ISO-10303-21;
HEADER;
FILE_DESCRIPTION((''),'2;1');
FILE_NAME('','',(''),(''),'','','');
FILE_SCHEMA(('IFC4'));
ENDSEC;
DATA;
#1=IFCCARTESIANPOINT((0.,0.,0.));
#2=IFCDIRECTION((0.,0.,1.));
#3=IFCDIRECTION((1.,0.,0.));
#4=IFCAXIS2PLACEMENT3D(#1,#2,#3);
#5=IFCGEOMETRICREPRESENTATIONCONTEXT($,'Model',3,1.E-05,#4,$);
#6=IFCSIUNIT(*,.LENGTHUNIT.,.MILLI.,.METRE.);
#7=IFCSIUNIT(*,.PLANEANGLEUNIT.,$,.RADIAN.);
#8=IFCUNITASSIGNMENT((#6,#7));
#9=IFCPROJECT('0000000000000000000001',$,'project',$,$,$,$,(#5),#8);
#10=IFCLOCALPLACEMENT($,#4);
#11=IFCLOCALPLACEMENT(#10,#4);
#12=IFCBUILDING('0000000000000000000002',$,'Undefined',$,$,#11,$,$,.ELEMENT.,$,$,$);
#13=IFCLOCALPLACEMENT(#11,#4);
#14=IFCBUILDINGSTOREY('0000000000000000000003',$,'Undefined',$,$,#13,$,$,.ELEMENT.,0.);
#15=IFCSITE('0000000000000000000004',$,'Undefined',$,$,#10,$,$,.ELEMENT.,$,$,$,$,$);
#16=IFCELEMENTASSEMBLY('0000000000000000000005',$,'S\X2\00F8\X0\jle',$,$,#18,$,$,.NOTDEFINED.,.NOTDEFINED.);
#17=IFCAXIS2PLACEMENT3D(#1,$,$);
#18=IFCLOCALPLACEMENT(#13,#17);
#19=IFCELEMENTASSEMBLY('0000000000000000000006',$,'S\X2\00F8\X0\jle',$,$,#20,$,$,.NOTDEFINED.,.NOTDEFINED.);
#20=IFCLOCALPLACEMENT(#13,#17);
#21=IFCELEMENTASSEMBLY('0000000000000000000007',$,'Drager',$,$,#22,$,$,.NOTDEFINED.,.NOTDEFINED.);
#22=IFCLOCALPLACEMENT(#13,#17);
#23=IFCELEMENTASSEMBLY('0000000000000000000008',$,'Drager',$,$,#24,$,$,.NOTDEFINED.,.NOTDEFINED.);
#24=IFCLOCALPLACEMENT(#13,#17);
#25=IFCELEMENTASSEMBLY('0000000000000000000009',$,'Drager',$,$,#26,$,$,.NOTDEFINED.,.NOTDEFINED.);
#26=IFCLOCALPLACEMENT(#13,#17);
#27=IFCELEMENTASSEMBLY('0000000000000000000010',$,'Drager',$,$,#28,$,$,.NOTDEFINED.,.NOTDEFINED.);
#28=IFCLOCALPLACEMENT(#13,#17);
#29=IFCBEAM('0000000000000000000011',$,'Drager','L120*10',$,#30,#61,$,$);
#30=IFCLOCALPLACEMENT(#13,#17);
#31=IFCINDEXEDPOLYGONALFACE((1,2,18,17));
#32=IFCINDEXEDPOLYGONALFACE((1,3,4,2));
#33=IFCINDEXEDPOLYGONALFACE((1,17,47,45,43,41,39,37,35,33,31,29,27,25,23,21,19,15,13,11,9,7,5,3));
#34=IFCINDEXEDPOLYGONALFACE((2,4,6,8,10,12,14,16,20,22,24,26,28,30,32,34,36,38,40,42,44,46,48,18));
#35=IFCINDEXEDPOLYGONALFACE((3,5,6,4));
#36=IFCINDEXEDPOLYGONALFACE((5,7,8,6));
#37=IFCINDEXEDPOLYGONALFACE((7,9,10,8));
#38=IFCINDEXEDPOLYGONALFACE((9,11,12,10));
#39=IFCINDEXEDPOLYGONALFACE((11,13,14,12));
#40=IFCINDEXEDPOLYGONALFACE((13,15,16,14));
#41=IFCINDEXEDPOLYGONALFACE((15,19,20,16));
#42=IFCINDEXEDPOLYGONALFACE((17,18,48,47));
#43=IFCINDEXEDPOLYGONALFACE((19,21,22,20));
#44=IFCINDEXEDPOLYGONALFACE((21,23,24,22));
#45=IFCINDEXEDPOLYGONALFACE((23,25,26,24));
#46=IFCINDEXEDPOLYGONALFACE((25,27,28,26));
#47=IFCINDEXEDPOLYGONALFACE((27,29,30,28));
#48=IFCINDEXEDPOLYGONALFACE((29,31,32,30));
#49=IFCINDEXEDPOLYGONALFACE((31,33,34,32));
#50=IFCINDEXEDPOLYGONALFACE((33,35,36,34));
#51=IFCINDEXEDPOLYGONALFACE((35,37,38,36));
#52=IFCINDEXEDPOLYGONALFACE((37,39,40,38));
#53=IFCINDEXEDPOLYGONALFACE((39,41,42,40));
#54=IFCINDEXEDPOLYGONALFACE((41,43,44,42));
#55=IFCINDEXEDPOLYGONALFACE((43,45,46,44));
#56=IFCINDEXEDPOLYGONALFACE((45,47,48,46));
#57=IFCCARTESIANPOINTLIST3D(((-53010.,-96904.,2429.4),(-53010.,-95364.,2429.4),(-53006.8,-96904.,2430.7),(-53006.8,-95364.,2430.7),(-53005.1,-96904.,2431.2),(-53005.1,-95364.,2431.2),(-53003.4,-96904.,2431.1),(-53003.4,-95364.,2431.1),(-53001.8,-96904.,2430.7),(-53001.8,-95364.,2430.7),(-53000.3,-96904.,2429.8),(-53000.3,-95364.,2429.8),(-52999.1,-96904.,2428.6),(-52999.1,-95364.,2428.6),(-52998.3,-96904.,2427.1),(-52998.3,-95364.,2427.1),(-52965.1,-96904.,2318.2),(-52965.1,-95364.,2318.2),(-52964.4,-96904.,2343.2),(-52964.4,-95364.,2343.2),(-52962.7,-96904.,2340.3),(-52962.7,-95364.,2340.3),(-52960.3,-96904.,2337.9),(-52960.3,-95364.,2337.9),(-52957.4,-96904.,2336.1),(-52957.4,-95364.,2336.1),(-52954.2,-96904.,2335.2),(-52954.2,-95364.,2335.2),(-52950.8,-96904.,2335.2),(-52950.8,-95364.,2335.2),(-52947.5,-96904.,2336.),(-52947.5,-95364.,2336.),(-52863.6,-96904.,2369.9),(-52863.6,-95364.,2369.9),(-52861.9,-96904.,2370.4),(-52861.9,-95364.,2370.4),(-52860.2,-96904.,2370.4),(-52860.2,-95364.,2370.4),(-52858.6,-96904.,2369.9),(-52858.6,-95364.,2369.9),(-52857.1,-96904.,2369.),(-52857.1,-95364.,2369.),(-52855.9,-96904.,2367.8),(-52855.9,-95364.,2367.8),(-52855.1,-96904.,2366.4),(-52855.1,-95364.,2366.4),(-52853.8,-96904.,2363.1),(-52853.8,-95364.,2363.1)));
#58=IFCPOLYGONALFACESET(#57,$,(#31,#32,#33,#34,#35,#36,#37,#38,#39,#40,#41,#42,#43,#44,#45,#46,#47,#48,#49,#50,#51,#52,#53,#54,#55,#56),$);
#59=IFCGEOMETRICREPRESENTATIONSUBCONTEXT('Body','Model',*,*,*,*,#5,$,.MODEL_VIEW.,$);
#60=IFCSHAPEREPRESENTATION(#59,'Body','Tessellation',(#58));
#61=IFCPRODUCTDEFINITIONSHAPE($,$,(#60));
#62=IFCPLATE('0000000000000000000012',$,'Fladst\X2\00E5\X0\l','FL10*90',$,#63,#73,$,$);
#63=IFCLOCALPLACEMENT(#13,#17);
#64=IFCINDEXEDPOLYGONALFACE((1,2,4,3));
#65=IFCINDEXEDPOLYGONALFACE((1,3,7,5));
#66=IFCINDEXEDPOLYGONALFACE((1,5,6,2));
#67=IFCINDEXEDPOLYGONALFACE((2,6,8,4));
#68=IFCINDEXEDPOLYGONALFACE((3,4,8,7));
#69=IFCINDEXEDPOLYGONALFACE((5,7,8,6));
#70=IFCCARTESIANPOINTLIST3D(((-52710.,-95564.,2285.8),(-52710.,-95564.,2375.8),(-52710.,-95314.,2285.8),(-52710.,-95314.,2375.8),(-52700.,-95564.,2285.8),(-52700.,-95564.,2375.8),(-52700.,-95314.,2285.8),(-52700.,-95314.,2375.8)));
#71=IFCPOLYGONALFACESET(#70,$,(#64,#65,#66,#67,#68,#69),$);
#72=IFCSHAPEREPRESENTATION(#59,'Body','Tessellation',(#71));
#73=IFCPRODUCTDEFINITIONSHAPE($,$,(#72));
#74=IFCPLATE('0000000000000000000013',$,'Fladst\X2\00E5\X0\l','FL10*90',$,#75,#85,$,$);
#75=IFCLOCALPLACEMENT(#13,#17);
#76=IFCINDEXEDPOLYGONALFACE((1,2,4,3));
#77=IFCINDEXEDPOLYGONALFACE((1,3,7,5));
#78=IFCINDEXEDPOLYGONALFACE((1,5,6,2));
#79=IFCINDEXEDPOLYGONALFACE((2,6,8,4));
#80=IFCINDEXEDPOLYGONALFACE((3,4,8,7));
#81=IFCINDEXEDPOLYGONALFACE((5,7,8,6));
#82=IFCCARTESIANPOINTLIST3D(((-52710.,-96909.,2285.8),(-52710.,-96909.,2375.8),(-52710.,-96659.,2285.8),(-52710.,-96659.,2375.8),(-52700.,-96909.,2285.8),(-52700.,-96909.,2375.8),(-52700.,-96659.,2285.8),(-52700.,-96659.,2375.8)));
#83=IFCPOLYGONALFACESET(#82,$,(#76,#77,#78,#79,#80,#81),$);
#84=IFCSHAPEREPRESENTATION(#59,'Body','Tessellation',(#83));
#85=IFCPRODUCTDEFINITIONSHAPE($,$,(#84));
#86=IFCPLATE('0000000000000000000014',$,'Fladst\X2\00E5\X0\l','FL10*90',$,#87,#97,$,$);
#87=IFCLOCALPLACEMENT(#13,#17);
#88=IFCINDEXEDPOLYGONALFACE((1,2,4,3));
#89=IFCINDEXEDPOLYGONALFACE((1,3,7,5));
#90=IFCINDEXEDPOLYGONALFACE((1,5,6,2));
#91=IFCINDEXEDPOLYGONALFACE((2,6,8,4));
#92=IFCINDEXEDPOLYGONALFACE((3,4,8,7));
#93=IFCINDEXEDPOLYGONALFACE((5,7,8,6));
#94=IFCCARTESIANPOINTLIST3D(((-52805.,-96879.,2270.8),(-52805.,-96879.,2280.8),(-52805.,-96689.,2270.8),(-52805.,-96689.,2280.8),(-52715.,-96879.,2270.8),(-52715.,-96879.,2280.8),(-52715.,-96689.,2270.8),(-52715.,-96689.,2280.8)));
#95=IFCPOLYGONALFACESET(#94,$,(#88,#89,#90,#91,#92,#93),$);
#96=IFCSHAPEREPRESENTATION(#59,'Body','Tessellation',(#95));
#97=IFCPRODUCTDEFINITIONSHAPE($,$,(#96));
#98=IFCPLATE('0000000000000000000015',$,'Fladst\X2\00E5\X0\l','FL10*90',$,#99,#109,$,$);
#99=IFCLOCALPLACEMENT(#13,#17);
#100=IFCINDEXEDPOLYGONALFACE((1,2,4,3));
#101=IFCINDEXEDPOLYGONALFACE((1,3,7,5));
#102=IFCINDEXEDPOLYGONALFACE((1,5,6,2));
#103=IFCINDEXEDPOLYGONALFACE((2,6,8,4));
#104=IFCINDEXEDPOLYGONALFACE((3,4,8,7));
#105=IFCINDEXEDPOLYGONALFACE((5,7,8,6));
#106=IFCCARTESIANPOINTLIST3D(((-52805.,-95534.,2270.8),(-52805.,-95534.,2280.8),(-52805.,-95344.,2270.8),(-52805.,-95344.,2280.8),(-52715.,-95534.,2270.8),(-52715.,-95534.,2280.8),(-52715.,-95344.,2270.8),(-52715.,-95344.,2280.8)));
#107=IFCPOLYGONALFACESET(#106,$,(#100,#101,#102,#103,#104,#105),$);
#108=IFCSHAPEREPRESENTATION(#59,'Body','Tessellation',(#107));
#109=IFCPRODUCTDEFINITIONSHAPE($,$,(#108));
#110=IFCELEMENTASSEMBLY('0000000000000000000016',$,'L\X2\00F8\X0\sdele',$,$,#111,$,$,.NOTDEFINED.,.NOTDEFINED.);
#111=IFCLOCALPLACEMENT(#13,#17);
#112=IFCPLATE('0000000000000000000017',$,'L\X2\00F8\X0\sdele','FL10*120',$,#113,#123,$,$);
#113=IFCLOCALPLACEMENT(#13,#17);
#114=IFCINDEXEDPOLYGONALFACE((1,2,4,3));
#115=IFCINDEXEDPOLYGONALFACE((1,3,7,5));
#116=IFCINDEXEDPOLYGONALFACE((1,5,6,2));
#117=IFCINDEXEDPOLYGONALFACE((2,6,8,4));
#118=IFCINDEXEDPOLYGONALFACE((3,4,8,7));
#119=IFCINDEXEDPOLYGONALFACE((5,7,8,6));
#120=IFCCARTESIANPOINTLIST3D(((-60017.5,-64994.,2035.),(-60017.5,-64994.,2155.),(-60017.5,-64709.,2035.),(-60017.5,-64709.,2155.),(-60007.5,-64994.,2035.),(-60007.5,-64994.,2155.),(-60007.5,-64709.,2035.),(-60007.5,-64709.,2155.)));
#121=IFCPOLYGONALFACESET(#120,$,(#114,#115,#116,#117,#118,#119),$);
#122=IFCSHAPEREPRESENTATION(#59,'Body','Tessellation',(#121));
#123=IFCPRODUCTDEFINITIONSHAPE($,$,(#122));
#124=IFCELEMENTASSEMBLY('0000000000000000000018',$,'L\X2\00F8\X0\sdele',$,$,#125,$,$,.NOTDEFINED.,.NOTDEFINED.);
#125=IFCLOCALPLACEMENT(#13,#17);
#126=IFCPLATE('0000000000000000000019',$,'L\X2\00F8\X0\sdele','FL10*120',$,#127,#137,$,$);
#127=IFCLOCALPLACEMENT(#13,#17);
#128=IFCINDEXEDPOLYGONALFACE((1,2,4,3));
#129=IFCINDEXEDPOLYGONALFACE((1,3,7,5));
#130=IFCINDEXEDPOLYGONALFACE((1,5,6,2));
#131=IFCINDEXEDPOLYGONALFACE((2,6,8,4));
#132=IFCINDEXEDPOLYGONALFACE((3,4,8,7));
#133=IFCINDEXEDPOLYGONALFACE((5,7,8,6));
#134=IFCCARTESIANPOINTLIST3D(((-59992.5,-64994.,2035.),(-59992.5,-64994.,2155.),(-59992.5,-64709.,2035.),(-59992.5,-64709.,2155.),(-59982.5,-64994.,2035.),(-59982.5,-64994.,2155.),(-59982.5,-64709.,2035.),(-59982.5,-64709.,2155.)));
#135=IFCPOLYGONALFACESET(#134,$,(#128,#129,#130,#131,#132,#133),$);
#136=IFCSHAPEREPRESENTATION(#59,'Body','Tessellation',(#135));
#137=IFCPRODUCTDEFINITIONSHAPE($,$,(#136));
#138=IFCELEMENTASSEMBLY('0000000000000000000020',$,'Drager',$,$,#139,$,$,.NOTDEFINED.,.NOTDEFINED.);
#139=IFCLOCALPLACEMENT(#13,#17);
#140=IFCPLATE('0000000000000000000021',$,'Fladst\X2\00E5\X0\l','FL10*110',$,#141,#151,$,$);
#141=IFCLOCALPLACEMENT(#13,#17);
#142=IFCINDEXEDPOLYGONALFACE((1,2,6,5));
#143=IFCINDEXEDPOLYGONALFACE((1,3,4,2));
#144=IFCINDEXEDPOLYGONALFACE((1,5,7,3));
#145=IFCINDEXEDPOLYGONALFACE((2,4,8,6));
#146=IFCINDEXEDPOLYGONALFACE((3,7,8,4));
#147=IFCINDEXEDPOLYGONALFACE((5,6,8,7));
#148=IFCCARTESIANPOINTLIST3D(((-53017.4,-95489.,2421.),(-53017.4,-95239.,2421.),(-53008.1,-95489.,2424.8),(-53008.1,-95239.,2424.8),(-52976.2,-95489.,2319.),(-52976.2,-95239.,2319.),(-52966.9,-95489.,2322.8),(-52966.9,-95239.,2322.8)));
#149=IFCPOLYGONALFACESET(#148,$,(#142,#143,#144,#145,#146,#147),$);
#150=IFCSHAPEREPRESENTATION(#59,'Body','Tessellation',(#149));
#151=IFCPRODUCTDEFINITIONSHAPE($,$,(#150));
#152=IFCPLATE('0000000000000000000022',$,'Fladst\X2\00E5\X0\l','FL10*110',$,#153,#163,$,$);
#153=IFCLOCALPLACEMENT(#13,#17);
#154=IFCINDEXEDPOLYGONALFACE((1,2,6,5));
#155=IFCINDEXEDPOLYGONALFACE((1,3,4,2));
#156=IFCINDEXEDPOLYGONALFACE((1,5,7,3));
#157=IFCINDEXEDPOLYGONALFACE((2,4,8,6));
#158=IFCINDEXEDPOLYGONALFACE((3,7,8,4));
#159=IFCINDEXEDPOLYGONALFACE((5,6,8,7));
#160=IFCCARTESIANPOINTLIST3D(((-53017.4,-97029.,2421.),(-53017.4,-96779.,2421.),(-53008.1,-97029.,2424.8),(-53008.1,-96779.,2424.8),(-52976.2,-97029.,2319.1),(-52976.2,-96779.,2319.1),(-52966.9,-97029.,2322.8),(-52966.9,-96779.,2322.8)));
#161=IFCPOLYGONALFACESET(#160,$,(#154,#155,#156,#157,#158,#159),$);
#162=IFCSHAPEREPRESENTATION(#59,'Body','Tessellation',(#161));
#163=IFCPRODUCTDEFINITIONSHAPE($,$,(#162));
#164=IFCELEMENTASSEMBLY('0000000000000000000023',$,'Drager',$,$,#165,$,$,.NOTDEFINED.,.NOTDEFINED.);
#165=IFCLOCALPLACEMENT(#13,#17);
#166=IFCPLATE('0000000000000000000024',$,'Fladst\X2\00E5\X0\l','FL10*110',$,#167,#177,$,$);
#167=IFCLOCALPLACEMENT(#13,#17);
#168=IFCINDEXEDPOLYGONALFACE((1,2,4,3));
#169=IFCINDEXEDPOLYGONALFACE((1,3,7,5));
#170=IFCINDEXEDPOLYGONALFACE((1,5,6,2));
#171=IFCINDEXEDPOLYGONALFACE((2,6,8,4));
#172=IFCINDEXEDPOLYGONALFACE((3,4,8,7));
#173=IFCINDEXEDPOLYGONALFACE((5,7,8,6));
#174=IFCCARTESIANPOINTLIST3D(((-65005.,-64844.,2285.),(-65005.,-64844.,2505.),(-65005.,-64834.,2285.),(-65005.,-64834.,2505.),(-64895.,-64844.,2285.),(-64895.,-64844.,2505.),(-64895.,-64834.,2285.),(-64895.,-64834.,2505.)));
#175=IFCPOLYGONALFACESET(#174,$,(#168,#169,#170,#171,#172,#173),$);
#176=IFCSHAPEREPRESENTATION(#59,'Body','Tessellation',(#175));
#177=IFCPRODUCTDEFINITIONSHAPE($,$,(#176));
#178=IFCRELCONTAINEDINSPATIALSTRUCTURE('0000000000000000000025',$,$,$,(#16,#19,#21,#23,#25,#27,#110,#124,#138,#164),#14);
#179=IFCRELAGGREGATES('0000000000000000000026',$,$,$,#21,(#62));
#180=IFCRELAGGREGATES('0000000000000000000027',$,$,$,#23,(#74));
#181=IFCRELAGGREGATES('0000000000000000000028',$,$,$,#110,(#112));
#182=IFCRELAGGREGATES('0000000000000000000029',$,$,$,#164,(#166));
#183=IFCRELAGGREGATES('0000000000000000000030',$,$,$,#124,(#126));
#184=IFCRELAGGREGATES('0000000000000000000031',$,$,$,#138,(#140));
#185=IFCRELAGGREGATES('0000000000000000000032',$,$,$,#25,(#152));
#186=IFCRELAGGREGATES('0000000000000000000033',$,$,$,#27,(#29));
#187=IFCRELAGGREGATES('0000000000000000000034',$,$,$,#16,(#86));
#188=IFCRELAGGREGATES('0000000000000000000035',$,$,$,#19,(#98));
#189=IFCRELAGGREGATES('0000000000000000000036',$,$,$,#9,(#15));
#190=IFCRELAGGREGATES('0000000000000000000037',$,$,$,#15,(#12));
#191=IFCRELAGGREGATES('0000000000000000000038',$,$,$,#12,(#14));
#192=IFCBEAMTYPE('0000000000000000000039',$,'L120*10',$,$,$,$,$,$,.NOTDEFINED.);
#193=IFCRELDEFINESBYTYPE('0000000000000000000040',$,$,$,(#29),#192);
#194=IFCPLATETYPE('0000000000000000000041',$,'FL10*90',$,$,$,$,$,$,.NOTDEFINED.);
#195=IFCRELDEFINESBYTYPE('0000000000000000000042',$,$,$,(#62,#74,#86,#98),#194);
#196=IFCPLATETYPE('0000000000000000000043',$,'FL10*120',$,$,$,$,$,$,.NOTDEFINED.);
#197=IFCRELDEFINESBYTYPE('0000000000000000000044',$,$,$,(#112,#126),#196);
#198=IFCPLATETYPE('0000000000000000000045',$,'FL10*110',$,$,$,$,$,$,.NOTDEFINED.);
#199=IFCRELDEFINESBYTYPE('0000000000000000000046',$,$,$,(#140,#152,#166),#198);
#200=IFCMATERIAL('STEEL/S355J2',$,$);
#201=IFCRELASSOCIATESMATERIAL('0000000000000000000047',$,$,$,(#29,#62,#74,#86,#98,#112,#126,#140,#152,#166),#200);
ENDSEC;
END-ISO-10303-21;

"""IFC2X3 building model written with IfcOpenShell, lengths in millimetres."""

from ifc_helpers import new_model, si_unit, frame, origin_with_axes, origin_2d_with_axis, place, context, subcontext, project, spatial, polyline, l_section, outline, extrude, material, type_object, element, aggregate, save


model = new_model("IFC2X3")

# Units and contexts
model_context = context("Model", 3, precision=1e-05, world=origin_with_axes())
body_context = subcontext(model_context, "Body", "Model", "MODEL_VIEW")
ifc_project = project(units=[si_unit("LENGTHUNIT", "METRE", prefix="MILLI"), si_unit("PLANEANGLEUNIT", "RADIAN")], contexts=[model_context])

# Site, building, storey
site_placement = place(None, origin_with_axes())
site = spatial("IfcSite", under=ifc_project, at=site_placement, Name="Undefined", CompositionType="ELEMENT")
building_placement = place(site_placement, origin_with_axes())
building = spatial("IfcBuilding", under=site, at=building_placement, Name="Undefined", CompositionType="ELEMENT")
storey_placement = place(building_placement, origin_with_axes())
storey = spatial("IfcBuildingStorey", under=building, at=storey_placement, Name="Undefined", CompositionType="ELEMENT", Elevation=0.0)

# Element assemblies
assembly_1_placement = place(storey_placement, origin_with_axes())
assembly_1 = element("IfcElementAssembly", 1, at=assembly_1_placement, inside=storey, Name="Søjle", AssemblyPlace="NOTDEFINED", PredefinedType="NOTDEFINED")
assembly_2_placement = place(storey_placement, origin_with_axes())
assembly_2 = element("IfcElementAssembly", 2, at=assembly_2_placement, inside=storey, Name="Søjle", AssemblyPlace="NOTDEFINED", PredefinedType="NOTDEFINED")

# Element assemblies
assembly_3_placement = place(storey_placement, origin_with_axes())
assembly_3 = element("IfcElementAssembly", 3, at=assembly_3_placement, inside=storey, Name="Drager", AssemblyPlace="NOTDEFINED", PredefinedType="NOTDEFINED")
assembly_4_placement = place(storey_placement, origin_with_axes())
assembly_4 = element("IfcElementAssembly", 4, at=assembly_4_placement, inside=storey, Name="Drager", AssemblyPlace="NOTDEFINED", PredefinedType="NOTDEFINED")

# Shared definitions
ifc_material_1 = material(Name="STEEL/S355J2")

# Element assembly
assembly_5_placement = place(storey_placement, origin_with_axes())
assembly_5 = element("IfcElementAssembly", 5, at=assembly_5_placement, inside=storey, Name="Drager", AssemblyPlace="NOTDEFINED", PredefinedType="NOTDEFINED")

# Element assembly, beam
assembly_6_placement = place(storey_placement, origin_with_axes())
assembly_6 = element("IfcElementAssembly", 6, at=assembly_6_placement, inside=storey, Name="Drager", AssemblyPlace="NOTDEFINED", PredefinedType="NOTDEFINED")
beam_type_1 = type_object("IfcBeamType", Name="L120*10", PredefinedType="NOTDEFINED")
beam_1_placement = place(assembly_6_placement, frame((-52931.9, -96904.0, 2396.3), z_axis=(-0.374607, -0.000002, 0.927184), x_axis=(-0.000001, 1.0, 0.000001)))
beam_1 = element("IfcBeam", 7, at=beam_1_placement, type_object=beam_type_1, material=ifc_material_1, Name="Drager", Description="L120*10", context=body_context, shape_type="SweptSolid", body=[
    extrude(l_section(Depth=120.0, Width=120.0, Thickness=10.0, FilletRadius=13.0, EdgeRadius=6.5, at=origin_2d_with_axis()), frame((1540.0, 0.0, 0.0), z_axis=(-1.0, 0.0, 0.0), x_axis=(0.0, -1.0, 0.0)), (0.0, 0.0, 1.0), 1540.0),
])

# Plates
plate_type_1 = type_object("IfcPlateType", Name="FL10*90", PredefinedType="NOTDEFINED")
plate_1_placement = place(assembly_3_placement, frame((-52705.0, -95564.0, 2330.8), z_axis=(1.0, 0.0, 0.0), x_axis=(0.0, 1.0, 0.0)))
plate_1 = element("IfcPlate", 8, at=plate_1_placement, type_object=plate_type_1, material=ifc_material_1, Name="Fladstål", Description="FL10*90", context=body_context, shape_type="SweptSolid", body=[
    extrude(outline(polyline([(0.0, -45.0), (0.0, 45.0), (250.0, 45.0), (250.0, -45.0), (0.0, -45.0)])), frame((0.0, 0.0, -5.0), z_axis=(0.0, 0.0, 1.0), x_axis=(1.0, 0.0, 0.0)), (0.0, 0.0, 1.0), 10.0),
])
aggregate(assembly_3, [plate_1])
plate_2_placement = place(assembly_4_placement, frame((-52705.0, -96909.0, 2330.8), z_axis=(1.0, 0.0, 0.0), x_axis=(0.0, 1.0, 0.0)))
plate_2 = element("IfcPlate", 9, at=plate_2_placement, type_object=plate_type_1, material=ifc_material_1, Name="Fladstål", Description="FL10*90", context=body_context, shape_type="SweptSolid", body=[
    extrude(outline(polyline([(0.0, -45.0), (0.0, 45.0), (250.0, 45.0), (250.0, -45.0), (0.0, -45.0)])), frame((0.0, 0.0, -5.0), z_axis=(0.0, 0.0, 1.0), x_axis=(1.0, 0.0, 0.0)), (0.0, 0.0, 1.0), 10.0),
])
aggregate(assembly_4, [plate_2])
plate_3_placement = place(assembly_1_placement, frame((-52760.0, -96879.0, 2275.8), z_axis=(0.0, 0.0, -1.0), x_axis=(0.0, 1.0, 0.0)))
plate_3 = element("IfcPlate", 10, at=plate_3_placement, type_object=plate_type_1, material=ifc_material_1, Name="Fladstål", Description="FL10*90", context=body_context, shape_type="SweptSolid", body=[
    extrude(outline(polyline([(0.0, -45.0), (0.0, 45.0), (190.0, 45.0), (190.0, -45.0), (0.0, -45.0)])), frame((0.0, 0.0, -5.0), z_axis=(0.0, 0.0, 1.0), x_axis=(1.0, 0.0, 0.0)), (0.0, 0.0, 1.0), 10.0),
])
plate_4_placement = place(assembly_2_placement, frame((-52760.0, -95534.0, 2275.8), z_axis=(0.0, 0.0, -1.0), x_axis=(0.0, 1.0, 0.0)))
plate_4 = element("IfcPlate", 11, at=plate_4_placement, type_object=plate_type_1, material=ifc_material_1, Name="Fladstål", Description="FL10*90", context=body_context, shape_type="SweptSolid", body=[
    extrude(outline(polyline([(0.0, -45.0), (0.0, 45.0), (190.0, 45.0), (190.0, -45.0), (0.0, -45.0)])), frame((0.0, 0.0, -5.0), z_axis=(0.0, 0.0, 1.0), x_axis=(1.0, 0.0, 0.0)), (0.0, 0.0, 1.0), 10.0),
])

# Element assemblies, plates
assembly_7_placement = place(storey_placement, origin_with_axes())
assembly_7 = element("IfcElementAssembly", 12, at=assembly_7_placement, inside=storey, Name="Løsdele", AssemblyPlace="NOTDEFINED", PredefinedType="NOTDEFINED")
plate_type_2 = type_object("IfcPlateType", Name="FL10*120", PredefinedType="NOTDEFINED")
plate_5_placement = place(assembly_7_placement, frame((-60012.5, -64994.0, 2095.0), z_axis=(1.0, 0.0, 0.0), x_axis=(0.0, 1.0, 0.0)))
plate_5 = element("IfcPlate", 13, at=plate_5_placement, type_object=plate_type_2, material=ifc_material_1, Name="Løsdele", Description="FL10*120", context=body_context, shape_type="SweptSolid", body=[
    extrude(outline(polyline([(0.0, -60.0), (0.0, 60.0), (285.0, 60.0), (285.0, -60.0), (0.0, -60.0)])), frame((0.0, 0.0, -5.0), z_axis=(0.0, 0.0, 1.0), x_axis=(1.0, 0.0, 0.0)), (0.0, 0.0, 1.0), 10.0),
])
aggregate(assembly_7, [plate_5])
assembly_8_placement = place(storey_placement, origin_with_axes())
assembly_8 = element("IfcElementAssembly", 14, at=assembly_8_placement, inside=storey, Name="Løsdele", AssemblyPlace="NOTDEFINED", PredefinedType="NOTDEFINED")
plate_6_placement = place(assembly_8_placement, frame((-59987.5, -64994.0, 2095.0), z_axis=(1.0, 0.0, 0.0), x_axis=(0.0, 1.0, 0.0)))
plate_6 = element("IfcPlate", 15, at=plate_6_placement, type_object=plate_type_2, material=ifc_material_1, Name="Løsdele", Description="FL10*120", context=body_context, shape_type="SweptSolid", body=[
    extrude(outline(polyline([(0.0, -60.0), (0.0, 60.0), (285.0, 60.0), (285.0, -60.0), (0.0, -60.0)])), frame((0.0, 0.0, -5.0), z_axis=(0.0, 0.0, 1.0), x_axis=(1.0, 0.0, 0.0)), (0.0, 0.0, 1.0), 10.0),
])
assembly_9_placement = place(storey_placement, origin_with_axes())
assembly_9 = element("IfcElementAssembly", 16, at=assembly_9_placement, inside=storey, Name="Drager", AssemblyPlace="NOTDEFINED", PredefinedType="NOTDEFINED")
plate_type_3 = type_object("IfcPlateType", Name="FL10*110", PredefinedType="NOTDEFINED")
plate_7_placement = place(assembly_9_placement, frame((-52992.2, -95239.0, 2371.9), z_axis=(0.927184, 0.0, 0.374606), x_axis=(0.0, -1.0, 0.0)))
plate_7 = element("IfcPlate", 17, at=plate_7_placement, type_object=plate_type_3, material=ifc_material_1, Name="Fladstål", Description="FL10*110", context=body_context, shape_type="SweptSolid", body=[
    extrude(outline(polyline([(0.0, -55.0), (0.0, 55.0), (250.0, 55.0), (250.0, -55.0), (0.0, -55.0)])), frame((0.0, 0.0, -5.0), z_axis=(0.0, 0.0, 1.0), x_axis=(1.0, 0.0, 0.0)), (0.0, 0.0, 1.0), 10.0),
])

# Plate
plate_8_placement = place(assembly_5_placement, frame((-52992.2, -97029.0, 2371.9), z_axis=(0.927184, 0.0, 0.374606), x_axis=(0.0, 1.0, 0.0)))
plate_8 = element("IfcPlate", 18, at=plate_8_placement, type_object=plate_type_3, material=ifc_material_1, Name="Fladstål", Description="FL10*110", context=body_context, shape_type="SweptSolid", body=[
    extrude(outline(polyline([(0.0, -55.0), (0.0, 55.0), (250.0, 55.0), (250.0, -55.0), (0.0, -55.0)])), frame((0.0, 0.0, -5.0), z_axis=(0.0, 0.0, 1.0), x_axis=(1.0, 0.0, 0.0)), (0.0, 0.0, 1.0), 10.0),
])

# Element assembly, plate
assembly_10_placement = place(storey_placement, origin_with_axes())
assembly_10 = element("IfcElementAssembly", 19, at=assembly_10_placement, inside=storey, Name="Drager", AssemblyPlace="NOTDEFINED", PredefinedType="NOTDEFINED")
plate_9_placement = place(assembly_10_placement, frame((-64950.0, -64839.0, 2285.0), z_axis=(0.0, 1.0, 0.0), x_axis=(0.0, 0.0, 1.0)))
plate_9 = element("IfcPlate", 20, at=plate_9_placement, type_object=plate_type_3, material=ifc_material_1, Name="Fladstål", Description="FL10*110", context=body_context, shape_type="SweptSolid", body=[
    extrude(outline(polyline([(0.0, -55.0), (0.0, 55.0), (220.0, 55.0), (220.0, -55.0), (0.0, -55.0)])), frame((0.0, 0.0, -5.0), z_axis=(0.0, 0.0, 1.0), x_axis=(1.0, 0.0, 0.0)), (0.0, 0.0, 1.0), 10.0),
])
aggregate(assembly_10, [plate_9])

aggregate(assembly_8, [plate_6])
aggregate(assembly_9, [plate_7])
aggregate(assembly_5, [plate_8])
aggregate(assembly_6, [beam_1])
aggregate(assembly_1, [plate_3])
aggregate(assembly_2, [plate_4])

save(model, "model.ifc")
